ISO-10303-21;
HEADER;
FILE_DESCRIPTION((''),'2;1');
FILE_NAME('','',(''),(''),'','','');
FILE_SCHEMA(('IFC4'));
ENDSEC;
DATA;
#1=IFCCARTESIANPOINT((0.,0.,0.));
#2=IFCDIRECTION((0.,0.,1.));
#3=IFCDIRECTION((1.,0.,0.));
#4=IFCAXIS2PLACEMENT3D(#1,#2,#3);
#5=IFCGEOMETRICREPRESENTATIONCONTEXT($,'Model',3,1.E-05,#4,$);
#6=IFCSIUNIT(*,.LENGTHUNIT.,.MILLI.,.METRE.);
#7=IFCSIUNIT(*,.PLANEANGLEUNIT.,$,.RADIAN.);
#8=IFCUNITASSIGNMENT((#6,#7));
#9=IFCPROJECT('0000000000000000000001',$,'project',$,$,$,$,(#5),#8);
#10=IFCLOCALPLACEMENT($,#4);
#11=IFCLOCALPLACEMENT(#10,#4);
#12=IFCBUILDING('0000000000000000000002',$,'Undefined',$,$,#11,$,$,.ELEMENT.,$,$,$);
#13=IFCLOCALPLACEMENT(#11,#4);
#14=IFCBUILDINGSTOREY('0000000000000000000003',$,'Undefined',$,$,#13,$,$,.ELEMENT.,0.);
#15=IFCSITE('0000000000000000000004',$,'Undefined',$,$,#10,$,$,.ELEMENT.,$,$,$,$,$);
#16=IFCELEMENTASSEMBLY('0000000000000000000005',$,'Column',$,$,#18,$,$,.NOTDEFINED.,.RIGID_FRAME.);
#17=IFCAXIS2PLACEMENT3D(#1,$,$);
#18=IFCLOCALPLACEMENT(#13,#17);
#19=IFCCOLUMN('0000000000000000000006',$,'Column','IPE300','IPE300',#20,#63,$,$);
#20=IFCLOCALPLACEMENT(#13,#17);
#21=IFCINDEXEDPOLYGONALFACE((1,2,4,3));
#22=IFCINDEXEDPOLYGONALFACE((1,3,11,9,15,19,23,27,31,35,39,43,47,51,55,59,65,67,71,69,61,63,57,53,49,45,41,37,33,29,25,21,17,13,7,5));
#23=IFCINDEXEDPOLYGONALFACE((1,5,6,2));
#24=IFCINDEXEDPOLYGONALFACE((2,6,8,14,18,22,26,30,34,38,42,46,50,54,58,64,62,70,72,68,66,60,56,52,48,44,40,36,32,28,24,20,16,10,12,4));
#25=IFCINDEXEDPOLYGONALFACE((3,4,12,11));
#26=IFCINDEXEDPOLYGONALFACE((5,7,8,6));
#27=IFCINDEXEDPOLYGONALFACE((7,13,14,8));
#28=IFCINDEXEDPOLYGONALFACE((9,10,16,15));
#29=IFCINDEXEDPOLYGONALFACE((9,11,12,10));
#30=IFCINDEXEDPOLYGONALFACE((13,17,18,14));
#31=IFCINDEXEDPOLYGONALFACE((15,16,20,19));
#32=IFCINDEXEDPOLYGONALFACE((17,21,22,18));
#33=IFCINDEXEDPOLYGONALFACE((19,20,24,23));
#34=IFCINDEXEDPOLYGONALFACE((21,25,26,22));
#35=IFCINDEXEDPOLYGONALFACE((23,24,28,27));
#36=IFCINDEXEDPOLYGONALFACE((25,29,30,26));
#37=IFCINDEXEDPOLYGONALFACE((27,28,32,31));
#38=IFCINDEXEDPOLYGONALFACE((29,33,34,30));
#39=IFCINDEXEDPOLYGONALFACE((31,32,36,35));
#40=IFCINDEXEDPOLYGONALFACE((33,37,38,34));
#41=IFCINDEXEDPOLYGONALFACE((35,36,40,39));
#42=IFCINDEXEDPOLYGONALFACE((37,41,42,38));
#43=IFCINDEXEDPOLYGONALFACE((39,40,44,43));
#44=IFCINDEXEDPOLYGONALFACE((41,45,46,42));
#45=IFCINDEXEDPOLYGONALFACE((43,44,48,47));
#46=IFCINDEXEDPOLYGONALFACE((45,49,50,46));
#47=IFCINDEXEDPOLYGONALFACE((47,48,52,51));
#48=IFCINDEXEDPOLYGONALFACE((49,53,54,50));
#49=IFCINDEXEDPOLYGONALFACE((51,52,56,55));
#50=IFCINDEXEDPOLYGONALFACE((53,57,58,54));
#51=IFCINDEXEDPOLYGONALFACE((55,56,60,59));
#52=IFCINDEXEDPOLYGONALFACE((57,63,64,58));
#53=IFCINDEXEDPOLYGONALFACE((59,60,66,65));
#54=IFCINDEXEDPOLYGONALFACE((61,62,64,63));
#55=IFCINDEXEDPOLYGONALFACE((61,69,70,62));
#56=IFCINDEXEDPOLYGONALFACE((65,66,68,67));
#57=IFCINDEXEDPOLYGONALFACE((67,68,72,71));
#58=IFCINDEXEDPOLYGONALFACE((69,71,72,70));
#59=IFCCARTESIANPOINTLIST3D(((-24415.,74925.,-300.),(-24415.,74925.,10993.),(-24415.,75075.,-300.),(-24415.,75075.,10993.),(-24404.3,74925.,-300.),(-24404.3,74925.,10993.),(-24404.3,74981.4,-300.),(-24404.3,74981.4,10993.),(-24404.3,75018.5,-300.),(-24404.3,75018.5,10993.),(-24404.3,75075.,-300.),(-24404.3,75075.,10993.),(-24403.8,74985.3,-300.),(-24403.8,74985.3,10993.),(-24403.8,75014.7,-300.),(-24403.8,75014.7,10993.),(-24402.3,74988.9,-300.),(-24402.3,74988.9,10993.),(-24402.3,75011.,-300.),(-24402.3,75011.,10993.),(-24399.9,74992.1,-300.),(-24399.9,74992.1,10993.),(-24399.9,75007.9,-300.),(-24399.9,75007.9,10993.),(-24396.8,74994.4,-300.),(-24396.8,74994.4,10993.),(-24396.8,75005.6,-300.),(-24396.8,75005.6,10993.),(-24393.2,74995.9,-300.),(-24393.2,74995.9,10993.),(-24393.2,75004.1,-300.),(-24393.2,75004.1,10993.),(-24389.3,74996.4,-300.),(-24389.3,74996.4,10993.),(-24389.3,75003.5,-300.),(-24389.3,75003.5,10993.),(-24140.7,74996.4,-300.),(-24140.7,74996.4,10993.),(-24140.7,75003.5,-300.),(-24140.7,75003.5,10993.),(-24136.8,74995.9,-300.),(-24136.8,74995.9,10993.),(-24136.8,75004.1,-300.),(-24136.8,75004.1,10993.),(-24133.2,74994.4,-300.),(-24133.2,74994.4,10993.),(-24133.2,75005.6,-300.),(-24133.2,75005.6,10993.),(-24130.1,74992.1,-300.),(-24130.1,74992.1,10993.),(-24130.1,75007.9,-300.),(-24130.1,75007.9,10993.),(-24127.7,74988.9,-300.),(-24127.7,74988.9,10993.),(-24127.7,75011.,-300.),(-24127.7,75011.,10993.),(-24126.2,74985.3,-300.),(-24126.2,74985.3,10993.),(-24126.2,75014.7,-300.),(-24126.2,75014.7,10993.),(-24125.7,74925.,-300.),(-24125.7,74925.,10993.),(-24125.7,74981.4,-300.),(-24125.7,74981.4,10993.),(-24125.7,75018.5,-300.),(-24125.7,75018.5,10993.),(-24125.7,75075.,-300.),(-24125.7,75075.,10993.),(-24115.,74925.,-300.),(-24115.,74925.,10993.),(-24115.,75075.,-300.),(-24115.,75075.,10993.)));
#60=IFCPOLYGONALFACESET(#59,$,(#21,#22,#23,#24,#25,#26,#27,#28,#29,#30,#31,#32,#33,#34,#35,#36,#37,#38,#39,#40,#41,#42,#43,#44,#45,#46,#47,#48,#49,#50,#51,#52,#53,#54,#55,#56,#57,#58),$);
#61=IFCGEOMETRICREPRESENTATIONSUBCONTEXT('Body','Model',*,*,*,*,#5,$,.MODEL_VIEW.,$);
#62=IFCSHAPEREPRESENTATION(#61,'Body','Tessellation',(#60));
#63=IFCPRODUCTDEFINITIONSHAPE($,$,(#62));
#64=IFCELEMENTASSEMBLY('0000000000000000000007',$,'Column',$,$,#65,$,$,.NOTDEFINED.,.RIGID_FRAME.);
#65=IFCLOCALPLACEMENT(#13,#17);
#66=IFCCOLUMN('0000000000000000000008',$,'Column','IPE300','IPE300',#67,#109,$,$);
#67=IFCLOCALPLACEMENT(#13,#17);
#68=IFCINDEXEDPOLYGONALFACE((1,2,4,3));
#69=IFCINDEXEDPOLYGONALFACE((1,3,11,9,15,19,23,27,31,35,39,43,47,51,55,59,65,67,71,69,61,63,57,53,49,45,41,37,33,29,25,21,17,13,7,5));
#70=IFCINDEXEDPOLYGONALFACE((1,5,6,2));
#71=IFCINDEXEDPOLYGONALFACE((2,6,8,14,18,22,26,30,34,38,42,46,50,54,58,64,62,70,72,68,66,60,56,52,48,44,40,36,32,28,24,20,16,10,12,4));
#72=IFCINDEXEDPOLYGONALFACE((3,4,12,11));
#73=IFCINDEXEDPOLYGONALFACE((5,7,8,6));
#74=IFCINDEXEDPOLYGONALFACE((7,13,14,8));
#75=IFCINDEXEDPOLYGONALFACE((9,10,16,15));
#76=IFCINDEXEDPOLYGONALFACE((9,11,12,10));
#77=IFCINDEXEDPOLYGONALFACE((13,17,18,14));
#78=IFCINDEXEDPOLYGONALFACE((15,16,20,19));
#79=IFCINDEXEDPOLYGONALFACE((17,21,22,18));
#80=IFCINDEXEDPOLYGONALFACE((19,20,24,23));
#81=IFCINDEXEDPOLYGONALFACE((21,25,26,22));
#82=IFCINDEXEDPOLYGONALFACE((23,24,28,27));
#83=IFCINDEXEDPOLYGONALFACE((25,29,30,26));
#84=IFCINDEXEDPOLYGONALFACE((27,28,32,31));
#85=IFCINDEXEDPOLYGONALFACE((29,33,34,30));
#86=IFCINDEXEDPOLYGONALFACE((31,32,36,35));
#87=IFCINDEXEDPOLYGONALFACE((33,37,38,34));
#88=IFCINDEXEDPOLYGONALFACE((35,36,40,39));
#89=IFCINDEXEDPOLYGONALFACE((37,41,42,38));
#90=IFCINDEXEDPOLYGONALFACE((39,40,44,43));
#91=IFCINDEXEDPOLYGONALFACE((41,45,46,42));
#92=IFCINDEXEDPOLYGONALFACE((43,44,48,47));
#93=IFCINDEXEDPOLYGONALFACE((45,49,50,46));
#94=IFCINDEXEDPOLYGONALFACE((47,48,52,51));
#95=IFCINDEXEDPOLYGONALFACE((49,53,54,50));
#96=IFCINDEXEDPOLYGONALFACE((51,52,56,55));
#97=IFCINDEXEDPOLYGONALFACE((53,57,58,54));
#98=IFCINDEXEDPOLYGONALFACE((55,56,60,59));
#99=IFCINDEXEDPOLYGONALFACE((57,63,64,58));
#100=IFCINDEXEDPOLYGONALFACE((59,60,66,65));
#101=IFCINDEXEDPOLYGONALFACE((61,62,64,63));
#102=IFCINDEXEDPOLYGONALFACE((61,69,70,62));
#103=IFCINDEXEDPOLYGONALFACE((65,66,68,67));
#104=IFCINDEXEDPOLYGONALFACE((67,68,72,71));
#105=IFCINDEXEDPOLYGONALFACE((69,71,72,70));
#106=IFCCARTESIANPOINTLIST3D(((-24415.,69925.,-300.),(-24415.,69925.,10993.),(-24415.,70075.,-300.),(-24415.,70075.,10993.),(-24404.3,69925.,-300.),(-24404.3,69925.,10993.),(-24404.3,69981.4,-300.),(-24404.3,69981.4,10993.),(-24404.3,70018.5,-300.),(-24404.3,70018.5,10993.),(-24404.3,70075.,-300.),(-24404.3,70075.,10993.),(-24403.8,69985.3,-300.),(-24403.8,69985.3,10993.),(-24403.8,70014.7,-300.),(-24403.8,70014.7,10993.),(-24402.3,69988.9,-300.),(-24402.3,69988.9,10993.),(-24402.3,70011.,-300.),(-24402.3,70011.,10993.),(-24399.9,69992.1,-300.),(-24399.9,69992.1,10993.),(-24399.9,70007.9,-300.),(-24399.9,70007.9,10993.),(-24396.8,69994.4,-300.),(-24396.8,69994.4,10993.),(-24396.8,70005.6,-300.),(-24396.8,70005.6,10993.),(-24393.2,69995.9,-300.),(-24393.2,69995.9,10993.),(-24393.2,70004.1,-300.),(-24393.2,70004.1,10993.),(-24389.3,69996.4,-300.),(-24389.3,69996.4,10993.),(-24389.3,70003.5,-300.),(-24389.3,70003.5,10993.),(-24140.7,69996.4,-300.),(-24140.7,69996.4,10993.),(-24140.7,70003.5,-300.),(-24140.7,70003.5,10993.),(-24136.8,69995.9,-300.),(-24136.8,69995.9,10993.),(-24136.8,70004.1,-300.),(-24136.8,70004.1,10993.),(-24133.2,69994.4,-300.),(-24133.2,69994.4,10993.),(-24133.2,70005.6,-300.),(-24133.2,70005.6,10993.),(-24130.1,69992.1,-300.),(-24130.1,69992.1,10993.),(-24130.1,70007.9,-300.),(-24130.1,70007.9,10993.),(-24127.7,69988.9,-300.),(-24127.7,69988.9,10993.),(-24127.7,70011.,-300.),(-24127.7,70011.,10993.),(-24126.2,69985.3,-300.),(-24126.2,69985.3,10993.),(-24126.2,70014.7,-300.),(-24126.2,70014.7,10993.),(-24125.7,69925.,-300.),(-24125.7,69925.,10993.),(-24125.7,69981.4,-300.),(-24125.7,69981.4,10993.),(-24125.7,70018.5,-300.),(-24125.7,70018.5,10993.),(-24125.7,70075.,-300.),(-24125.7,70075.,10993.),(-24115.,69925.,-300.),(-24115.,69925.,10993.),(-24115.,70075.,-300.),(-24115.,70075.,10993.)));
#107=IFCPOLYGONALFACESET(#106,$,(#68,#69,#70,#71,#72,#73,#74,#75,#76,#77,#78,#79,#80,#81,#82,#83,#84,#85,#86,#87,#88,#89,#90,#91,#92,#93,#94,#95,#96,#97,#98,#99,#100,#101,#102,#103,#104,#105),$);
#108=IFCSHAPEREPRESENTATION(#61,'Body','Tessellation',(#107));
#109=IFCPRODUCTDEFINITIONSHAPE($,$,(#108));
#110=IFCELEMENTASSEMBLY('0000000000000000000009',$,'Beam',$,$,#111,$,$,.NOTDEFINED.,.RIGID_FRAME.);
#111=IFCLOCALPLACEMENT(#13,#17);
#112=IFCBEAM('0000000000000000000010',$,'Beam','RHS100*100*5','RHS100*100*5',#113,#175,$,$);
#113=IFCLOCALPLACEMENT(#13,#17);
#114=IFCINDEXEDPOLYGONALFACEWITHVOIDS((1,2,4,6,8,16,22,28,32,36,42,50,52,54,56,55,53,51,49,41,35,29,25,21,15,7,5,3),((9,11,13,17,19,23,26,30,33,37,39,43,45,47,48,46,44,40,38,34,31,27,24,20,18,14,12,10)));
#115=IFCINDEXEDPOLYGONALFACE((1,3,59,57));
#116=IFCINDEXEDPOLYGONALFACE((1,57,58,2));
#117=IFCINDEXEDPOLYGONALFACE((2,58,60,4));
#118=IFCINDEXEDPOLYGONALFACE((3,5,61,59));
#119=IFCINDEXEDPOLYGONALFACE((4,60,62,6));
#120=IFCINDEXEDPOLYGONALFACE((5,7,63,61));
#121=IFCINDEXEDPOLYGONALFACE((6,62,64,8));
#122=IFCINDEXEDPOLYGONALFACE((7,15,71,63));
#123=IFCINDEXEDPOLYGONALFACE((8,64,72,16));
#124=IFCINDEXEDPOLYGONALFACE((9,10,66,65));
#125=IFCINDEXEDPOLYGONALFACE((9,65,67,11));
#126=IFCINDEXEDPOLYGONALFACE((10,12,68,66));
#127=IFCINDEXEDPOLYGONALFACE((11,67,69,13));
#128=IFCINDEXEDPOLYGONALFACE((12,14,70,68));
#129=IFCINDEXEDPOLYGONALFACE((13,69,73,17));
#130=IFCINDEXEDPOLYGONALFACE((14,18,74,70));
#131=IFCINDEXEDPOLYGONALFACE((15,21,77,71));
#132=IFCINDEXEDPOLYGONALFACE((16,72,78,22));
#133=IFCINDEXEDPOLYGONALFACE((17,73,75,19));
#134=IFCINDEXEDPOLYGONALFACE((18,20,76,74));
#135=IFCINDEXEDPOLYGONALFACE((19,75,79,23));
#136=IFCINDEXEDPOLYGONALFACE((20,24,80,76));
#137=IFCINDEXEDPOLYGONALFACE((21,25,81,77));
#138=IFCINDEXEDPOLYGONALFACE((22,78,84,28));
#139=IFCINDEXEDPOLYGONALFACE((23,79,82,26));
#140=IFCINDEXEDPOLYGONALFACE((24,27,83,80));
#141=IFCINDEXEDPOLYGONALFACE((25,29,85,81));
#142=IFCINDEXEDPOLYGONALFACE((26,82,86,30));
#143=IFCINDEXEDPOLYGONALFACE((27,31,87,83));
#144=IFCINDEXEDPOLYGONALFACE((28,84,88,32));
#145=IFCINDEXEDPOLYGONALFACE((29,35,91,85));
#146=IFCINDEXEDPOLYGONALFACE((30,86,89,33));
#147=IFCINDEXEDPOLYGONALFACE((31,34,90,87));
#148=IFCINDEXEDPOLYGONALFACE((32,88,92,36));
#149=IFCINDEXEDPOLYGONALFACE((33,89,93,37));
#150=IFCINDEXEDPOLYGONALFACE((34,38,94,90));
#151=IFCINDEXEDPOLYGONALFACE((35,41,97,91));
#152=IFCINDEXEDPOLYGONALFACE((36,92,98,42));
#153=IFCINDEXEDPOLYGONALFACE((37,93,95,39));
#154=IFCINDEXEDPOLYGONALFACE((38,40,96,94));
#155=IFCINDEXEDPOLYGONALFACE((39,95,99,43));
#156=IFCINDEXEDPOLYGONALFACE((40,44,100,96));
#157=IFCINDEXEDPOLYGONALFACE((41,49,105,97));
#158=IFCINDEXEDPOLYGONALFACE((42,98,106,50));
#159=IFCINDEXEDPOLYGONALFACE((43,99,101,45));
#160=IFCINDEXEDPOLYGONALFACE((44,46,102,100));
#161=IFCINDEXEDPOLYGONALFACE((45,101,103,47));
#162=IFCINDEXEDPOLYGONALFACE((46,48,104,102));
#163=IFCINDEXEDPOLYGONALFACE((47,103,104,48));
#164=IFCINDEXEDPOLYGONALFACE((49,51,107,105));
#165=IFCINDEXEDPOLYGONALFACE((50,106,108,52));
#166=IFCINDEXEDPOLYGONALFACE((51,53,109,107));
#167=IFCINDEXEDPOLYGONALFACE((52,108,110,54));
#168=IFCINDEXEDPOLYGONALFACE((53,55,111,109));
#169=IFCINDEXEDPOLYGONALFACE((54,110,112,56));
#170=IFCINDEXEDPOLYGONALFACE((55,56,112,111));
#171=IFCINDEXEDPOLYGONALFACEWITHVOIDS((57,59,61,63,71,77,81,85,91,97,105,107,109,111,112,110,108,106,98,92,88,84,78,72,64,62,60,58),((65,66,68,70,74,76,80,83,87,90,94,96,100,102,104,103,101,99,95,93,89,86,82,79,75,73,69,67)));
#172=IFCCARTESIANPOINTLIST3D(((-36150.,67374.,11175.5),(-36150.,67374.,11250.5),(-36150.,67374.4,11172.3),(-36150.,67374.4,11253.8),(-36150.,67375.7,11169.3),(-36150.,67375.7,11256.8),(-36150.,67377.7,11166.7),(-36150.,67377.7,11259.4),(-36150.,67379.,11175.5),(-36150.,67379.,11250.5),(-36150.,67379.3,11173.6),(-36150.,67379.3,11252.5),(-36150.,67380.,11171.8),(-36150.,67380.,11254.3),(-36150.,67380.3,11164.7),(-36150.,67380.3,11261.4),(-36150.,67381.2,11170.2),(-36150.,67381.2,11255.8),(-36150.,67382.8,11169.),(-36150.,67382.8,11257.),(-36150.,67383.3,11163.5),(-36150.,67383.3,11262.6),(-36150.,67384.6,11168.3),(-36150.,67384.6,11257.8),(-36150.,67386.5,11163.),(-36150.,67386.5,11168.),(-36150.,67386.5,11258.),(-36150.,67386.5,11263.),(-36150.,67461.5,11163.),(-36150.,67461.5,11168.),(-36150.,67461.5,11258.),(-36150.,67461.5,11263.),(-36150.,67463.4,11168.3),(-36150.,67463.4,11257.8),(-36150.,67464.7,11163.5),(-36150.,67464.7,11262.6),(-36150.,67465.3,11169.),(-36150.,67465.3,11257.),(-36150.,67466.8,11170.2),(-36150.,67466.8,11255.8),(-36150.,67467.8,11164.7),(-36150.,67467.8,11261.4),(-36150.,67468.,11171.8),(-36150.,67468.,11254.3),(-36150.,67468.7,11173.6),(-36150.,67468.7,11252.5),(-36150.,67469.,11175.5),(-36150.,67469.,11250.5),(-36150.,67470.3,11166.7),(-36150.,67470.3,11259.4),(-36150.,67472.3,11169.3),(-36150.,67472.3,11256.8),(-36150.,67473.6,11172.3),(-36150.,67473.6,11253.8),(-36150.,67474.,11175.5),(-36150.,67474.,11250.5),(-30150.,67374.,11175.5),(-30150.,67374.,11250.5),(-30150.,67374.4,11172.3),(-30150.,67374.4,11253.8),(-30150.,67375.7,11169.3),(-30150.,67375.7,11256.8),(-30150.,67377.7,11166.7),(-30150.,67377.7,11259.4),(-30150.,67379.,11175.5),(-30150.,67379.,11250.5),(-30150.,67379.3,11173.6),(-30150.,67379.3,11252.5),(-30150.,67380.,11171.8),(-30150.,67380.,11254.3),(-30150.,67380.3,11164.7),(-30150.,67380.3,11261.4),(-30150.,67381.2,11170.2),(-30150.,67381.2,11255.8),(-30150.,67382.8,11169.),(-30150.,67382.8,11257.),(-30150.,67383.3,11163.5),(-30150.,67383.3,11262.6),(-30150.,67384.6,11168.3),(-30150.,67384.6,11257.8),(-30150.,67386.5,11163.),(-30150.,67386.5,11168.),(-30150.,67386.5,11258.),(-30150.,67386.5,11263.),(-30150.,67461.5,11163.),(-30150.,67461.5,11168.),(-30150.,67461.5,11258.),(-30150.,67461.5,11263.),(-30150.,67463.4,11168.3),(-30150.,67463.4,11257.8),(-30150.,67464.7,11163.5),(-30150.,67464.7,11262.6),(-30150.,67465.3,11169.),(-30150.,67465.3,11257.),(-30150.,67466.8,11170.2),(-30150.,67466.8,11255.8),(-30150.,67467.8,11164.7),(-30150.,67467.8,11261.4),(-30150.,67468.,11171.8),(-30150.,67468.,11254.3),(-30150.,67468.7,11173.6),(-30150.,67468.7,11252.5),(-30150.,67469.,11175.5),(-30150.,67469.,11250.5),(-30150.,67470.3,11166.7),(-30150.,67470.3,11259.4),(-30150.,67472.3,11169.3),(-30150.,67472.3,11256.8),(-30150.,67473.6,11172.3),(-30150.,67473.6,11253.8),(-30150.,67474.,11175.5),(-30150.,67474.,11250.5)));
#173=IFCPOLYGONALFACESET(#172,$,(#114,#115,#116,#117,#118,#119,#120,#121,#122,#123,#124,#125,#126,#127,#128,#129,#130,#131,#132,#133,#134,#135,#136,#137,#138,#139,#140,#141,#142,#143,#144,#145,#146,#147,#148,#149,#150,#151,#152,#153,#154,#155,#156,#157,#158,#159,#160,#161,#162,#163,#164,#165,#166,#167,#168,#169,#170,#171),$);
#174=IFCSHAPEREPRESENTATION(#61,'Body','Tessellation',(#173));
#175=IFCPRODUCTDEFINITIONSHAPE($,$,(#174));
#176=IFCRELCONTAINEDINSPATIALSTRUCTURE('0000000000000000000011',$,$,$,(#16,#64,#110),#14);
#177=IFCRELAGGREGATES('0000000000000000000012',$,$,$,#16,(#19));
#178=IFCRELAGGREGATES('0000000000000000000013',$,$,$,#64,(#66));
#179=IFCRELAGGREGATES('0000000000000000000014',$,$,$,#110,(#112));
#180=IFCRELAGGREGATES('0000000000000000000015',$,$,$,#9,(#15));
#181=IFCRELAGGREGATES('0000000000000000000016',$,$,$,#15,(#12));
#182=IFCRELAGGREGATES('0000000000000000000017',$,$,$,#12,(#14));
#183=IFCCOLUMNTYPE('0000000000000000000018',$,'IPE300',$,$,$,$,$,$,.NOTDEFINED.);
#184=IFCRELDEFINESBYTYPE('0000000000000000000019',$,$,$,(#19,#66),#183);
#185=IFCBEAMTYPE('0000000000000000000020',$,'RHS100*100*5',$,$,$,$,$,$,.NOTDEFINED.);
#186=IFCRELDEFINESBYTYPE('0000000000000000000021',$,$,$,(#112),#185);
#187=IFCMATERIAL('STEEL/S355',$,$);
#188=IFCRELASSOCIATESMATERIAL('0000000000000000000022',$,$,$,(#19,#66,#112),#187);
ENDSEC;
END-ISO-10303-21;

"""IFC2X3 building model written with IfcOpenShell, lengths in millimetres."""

from ifc_helpers import new_model, si_unit, frame, origin_with_axes, origin_2d_with_axis, place, context, subcontext, project, spatial, hollow_rectangle, i_section, extrude, material, type_object, element, aggregate, save


model = new_model("IFC2X3")

# Units and contexts
model_context = context("Model", 3, precision=1e-05, world=origin_with_axes())
body_context = subcontext(model_context, "Body", "Model", "MODEL_VIEW")
ifc_project = project(units=[si_unit("LENGTHUNIT", "METRE", prefix="MILLI"), si_unit("PLANEANGLEUNIT", "RADIAN")], contexts=[model_context])

# Site, building, storey
site_placement = place(None, origin_with_axes())
site = spatial("IfcSite", under=ifc_project, at=site_placement, Name="Undefined", CompositionType="ELEMENT")
building_placement = place(site_placement, origin_with_axes())
building = spatial("IfcBuilding", under=site, at=building_placement, Name="Undefined", CompositionType="ELEMENT")
storey_placement = place(building_placement, origin_with_axes())
storey = spatial("IfcBuildingStorey", under=building, at=storey_placement, Name="Undefined", CompositionType="ELEMENT", Elevation=0.0)

# Element assemblies, columns
assembly_1_placement = place(storey_placement, origin_with_axes())
assembly_1 = element("IfcElementAssembly", 1, at=assembly_1_placement, inside=storey, Name="Column", AssemblyPlace="NOTDEFINED", PredefinedType="RIGID_FRAME")
ifc_material = material(Name="STEEL/S355")
column_type = type_object("IfcColumnType", Name="IPE300", PredefinedType="NOTDEFINED")
column_1_placement = place(assembly_1_placement, frame((-24265.0, 75000.0, -300.0), z_axis=(0.0, 0.0, 1.0), x_axis=(1.0, 0.0, 0.0)))
column_1 = element("IfcColumn", 2, at=column_1_placement, type_object=column_type, material=ifc_material, Name="Column", Description="IPE300", ObjectType="IPE300", context=body_context, shape_type="SweptSolid", body=[
    extrude(i_section(OverallWidth=150.0, OverallDepth=300.0, WebThickness=7.1, FlangeThickness=10.7, FilletRadius=15.0, at=origin_2d_with_axis()), frame((0.0, 0.0, 11293.0), z_axis=(0.0, 0.0, -1.0), x_axis=(0.0, 1.0, 0.0)), (0.0, 0.0, 1.0), 11293.0),
])
aggregate(assembly_1, [column_1])
assembly_2_placement = place(storey_placement, origin_with_axes())
assembly_2 = element("IfcElementAssembly", 3, at=assembly_2_placement, inside=storey, Name="Column", AssemblyPlace="NOTDEFINED", PredefinedType="RIGID_FRAME")
column_2_placement = place(assembly_2_placement, frame((-24265.0, 70000.0, -300.0), z_axis=(0.0, 0.0, 1.0), x_axis=(1.0, 0.0, 0.0)))
column_2 = element("IfcColumn", 4, at=column_2_placement, type_object=column_type, material=ifc_material, Name="Column", Description="IPE300", ObjectType="IPE300", context=body_context, shape_type="SweptSolid", body=[
    extrude(i_section(OverallWidth=150.0, OverallDepth=300.0, WebThickness=7.1, FlangeThickness=10.7, FilletRadius=15.0, at=origin_2d_with_axis()), frame((0.0, 0.0, 11293.0), z_axis=(0.0, 0.0, -1.0), x_axis=(0.0, 1.0, 0.0)), (0.0, 0.0, 1.0), 11293.0),
])
aggregate(assembly_2, [column_2])

# Element assembly, beam
assembly_3_placement = place(storey_placement, origin_with_axes())
assembly_3 = element("IfcElementAssembly", 5, at=assembly_3_placement, inside=storey, Name="Beam", AssemblyPlace="NOTDEFINED", PredefinedType="RIGID_FRAME")
beam_type_1 = type_object("IfcBeamType", Name="RHS100*100*5", PredefinedType="NOTDEFINED")
beam_1_placement = place(assembly_3_placement, frame((-30150.0, 67424.0, 11213.0), z_axis=(0.0, 0.0, 1.0), x_axis=(-1.0, 0.0, 0.0)))
beam_1 = element("IfcBeam", 6, at=beam_1_placement, type_object=beam_type_1, material=ifc_material, Name="Beam", Description="RHS100*100*5", ObjectType="RHS100*100*5", context=body_context, shape_type="SweptSolid", body=[
    extrude(hollow_rectangle(XDim=100.0, YDim=100.0, WallThickness=5.0, InnerFilletRadius=7.5, OuterFilletRadius=12.5, at=origin_2d_with_axis()), frame((6000.0, 0.0, 0.0), z_axis=(-1.0, 0.0, 0.0), x_axis=(0.0, -1.0, 0.0)), (0.0, 0.0, 1.0), 6000.0),
])
aggregate(assembly_3, [beam_1])

save(model, "model.ifc")
